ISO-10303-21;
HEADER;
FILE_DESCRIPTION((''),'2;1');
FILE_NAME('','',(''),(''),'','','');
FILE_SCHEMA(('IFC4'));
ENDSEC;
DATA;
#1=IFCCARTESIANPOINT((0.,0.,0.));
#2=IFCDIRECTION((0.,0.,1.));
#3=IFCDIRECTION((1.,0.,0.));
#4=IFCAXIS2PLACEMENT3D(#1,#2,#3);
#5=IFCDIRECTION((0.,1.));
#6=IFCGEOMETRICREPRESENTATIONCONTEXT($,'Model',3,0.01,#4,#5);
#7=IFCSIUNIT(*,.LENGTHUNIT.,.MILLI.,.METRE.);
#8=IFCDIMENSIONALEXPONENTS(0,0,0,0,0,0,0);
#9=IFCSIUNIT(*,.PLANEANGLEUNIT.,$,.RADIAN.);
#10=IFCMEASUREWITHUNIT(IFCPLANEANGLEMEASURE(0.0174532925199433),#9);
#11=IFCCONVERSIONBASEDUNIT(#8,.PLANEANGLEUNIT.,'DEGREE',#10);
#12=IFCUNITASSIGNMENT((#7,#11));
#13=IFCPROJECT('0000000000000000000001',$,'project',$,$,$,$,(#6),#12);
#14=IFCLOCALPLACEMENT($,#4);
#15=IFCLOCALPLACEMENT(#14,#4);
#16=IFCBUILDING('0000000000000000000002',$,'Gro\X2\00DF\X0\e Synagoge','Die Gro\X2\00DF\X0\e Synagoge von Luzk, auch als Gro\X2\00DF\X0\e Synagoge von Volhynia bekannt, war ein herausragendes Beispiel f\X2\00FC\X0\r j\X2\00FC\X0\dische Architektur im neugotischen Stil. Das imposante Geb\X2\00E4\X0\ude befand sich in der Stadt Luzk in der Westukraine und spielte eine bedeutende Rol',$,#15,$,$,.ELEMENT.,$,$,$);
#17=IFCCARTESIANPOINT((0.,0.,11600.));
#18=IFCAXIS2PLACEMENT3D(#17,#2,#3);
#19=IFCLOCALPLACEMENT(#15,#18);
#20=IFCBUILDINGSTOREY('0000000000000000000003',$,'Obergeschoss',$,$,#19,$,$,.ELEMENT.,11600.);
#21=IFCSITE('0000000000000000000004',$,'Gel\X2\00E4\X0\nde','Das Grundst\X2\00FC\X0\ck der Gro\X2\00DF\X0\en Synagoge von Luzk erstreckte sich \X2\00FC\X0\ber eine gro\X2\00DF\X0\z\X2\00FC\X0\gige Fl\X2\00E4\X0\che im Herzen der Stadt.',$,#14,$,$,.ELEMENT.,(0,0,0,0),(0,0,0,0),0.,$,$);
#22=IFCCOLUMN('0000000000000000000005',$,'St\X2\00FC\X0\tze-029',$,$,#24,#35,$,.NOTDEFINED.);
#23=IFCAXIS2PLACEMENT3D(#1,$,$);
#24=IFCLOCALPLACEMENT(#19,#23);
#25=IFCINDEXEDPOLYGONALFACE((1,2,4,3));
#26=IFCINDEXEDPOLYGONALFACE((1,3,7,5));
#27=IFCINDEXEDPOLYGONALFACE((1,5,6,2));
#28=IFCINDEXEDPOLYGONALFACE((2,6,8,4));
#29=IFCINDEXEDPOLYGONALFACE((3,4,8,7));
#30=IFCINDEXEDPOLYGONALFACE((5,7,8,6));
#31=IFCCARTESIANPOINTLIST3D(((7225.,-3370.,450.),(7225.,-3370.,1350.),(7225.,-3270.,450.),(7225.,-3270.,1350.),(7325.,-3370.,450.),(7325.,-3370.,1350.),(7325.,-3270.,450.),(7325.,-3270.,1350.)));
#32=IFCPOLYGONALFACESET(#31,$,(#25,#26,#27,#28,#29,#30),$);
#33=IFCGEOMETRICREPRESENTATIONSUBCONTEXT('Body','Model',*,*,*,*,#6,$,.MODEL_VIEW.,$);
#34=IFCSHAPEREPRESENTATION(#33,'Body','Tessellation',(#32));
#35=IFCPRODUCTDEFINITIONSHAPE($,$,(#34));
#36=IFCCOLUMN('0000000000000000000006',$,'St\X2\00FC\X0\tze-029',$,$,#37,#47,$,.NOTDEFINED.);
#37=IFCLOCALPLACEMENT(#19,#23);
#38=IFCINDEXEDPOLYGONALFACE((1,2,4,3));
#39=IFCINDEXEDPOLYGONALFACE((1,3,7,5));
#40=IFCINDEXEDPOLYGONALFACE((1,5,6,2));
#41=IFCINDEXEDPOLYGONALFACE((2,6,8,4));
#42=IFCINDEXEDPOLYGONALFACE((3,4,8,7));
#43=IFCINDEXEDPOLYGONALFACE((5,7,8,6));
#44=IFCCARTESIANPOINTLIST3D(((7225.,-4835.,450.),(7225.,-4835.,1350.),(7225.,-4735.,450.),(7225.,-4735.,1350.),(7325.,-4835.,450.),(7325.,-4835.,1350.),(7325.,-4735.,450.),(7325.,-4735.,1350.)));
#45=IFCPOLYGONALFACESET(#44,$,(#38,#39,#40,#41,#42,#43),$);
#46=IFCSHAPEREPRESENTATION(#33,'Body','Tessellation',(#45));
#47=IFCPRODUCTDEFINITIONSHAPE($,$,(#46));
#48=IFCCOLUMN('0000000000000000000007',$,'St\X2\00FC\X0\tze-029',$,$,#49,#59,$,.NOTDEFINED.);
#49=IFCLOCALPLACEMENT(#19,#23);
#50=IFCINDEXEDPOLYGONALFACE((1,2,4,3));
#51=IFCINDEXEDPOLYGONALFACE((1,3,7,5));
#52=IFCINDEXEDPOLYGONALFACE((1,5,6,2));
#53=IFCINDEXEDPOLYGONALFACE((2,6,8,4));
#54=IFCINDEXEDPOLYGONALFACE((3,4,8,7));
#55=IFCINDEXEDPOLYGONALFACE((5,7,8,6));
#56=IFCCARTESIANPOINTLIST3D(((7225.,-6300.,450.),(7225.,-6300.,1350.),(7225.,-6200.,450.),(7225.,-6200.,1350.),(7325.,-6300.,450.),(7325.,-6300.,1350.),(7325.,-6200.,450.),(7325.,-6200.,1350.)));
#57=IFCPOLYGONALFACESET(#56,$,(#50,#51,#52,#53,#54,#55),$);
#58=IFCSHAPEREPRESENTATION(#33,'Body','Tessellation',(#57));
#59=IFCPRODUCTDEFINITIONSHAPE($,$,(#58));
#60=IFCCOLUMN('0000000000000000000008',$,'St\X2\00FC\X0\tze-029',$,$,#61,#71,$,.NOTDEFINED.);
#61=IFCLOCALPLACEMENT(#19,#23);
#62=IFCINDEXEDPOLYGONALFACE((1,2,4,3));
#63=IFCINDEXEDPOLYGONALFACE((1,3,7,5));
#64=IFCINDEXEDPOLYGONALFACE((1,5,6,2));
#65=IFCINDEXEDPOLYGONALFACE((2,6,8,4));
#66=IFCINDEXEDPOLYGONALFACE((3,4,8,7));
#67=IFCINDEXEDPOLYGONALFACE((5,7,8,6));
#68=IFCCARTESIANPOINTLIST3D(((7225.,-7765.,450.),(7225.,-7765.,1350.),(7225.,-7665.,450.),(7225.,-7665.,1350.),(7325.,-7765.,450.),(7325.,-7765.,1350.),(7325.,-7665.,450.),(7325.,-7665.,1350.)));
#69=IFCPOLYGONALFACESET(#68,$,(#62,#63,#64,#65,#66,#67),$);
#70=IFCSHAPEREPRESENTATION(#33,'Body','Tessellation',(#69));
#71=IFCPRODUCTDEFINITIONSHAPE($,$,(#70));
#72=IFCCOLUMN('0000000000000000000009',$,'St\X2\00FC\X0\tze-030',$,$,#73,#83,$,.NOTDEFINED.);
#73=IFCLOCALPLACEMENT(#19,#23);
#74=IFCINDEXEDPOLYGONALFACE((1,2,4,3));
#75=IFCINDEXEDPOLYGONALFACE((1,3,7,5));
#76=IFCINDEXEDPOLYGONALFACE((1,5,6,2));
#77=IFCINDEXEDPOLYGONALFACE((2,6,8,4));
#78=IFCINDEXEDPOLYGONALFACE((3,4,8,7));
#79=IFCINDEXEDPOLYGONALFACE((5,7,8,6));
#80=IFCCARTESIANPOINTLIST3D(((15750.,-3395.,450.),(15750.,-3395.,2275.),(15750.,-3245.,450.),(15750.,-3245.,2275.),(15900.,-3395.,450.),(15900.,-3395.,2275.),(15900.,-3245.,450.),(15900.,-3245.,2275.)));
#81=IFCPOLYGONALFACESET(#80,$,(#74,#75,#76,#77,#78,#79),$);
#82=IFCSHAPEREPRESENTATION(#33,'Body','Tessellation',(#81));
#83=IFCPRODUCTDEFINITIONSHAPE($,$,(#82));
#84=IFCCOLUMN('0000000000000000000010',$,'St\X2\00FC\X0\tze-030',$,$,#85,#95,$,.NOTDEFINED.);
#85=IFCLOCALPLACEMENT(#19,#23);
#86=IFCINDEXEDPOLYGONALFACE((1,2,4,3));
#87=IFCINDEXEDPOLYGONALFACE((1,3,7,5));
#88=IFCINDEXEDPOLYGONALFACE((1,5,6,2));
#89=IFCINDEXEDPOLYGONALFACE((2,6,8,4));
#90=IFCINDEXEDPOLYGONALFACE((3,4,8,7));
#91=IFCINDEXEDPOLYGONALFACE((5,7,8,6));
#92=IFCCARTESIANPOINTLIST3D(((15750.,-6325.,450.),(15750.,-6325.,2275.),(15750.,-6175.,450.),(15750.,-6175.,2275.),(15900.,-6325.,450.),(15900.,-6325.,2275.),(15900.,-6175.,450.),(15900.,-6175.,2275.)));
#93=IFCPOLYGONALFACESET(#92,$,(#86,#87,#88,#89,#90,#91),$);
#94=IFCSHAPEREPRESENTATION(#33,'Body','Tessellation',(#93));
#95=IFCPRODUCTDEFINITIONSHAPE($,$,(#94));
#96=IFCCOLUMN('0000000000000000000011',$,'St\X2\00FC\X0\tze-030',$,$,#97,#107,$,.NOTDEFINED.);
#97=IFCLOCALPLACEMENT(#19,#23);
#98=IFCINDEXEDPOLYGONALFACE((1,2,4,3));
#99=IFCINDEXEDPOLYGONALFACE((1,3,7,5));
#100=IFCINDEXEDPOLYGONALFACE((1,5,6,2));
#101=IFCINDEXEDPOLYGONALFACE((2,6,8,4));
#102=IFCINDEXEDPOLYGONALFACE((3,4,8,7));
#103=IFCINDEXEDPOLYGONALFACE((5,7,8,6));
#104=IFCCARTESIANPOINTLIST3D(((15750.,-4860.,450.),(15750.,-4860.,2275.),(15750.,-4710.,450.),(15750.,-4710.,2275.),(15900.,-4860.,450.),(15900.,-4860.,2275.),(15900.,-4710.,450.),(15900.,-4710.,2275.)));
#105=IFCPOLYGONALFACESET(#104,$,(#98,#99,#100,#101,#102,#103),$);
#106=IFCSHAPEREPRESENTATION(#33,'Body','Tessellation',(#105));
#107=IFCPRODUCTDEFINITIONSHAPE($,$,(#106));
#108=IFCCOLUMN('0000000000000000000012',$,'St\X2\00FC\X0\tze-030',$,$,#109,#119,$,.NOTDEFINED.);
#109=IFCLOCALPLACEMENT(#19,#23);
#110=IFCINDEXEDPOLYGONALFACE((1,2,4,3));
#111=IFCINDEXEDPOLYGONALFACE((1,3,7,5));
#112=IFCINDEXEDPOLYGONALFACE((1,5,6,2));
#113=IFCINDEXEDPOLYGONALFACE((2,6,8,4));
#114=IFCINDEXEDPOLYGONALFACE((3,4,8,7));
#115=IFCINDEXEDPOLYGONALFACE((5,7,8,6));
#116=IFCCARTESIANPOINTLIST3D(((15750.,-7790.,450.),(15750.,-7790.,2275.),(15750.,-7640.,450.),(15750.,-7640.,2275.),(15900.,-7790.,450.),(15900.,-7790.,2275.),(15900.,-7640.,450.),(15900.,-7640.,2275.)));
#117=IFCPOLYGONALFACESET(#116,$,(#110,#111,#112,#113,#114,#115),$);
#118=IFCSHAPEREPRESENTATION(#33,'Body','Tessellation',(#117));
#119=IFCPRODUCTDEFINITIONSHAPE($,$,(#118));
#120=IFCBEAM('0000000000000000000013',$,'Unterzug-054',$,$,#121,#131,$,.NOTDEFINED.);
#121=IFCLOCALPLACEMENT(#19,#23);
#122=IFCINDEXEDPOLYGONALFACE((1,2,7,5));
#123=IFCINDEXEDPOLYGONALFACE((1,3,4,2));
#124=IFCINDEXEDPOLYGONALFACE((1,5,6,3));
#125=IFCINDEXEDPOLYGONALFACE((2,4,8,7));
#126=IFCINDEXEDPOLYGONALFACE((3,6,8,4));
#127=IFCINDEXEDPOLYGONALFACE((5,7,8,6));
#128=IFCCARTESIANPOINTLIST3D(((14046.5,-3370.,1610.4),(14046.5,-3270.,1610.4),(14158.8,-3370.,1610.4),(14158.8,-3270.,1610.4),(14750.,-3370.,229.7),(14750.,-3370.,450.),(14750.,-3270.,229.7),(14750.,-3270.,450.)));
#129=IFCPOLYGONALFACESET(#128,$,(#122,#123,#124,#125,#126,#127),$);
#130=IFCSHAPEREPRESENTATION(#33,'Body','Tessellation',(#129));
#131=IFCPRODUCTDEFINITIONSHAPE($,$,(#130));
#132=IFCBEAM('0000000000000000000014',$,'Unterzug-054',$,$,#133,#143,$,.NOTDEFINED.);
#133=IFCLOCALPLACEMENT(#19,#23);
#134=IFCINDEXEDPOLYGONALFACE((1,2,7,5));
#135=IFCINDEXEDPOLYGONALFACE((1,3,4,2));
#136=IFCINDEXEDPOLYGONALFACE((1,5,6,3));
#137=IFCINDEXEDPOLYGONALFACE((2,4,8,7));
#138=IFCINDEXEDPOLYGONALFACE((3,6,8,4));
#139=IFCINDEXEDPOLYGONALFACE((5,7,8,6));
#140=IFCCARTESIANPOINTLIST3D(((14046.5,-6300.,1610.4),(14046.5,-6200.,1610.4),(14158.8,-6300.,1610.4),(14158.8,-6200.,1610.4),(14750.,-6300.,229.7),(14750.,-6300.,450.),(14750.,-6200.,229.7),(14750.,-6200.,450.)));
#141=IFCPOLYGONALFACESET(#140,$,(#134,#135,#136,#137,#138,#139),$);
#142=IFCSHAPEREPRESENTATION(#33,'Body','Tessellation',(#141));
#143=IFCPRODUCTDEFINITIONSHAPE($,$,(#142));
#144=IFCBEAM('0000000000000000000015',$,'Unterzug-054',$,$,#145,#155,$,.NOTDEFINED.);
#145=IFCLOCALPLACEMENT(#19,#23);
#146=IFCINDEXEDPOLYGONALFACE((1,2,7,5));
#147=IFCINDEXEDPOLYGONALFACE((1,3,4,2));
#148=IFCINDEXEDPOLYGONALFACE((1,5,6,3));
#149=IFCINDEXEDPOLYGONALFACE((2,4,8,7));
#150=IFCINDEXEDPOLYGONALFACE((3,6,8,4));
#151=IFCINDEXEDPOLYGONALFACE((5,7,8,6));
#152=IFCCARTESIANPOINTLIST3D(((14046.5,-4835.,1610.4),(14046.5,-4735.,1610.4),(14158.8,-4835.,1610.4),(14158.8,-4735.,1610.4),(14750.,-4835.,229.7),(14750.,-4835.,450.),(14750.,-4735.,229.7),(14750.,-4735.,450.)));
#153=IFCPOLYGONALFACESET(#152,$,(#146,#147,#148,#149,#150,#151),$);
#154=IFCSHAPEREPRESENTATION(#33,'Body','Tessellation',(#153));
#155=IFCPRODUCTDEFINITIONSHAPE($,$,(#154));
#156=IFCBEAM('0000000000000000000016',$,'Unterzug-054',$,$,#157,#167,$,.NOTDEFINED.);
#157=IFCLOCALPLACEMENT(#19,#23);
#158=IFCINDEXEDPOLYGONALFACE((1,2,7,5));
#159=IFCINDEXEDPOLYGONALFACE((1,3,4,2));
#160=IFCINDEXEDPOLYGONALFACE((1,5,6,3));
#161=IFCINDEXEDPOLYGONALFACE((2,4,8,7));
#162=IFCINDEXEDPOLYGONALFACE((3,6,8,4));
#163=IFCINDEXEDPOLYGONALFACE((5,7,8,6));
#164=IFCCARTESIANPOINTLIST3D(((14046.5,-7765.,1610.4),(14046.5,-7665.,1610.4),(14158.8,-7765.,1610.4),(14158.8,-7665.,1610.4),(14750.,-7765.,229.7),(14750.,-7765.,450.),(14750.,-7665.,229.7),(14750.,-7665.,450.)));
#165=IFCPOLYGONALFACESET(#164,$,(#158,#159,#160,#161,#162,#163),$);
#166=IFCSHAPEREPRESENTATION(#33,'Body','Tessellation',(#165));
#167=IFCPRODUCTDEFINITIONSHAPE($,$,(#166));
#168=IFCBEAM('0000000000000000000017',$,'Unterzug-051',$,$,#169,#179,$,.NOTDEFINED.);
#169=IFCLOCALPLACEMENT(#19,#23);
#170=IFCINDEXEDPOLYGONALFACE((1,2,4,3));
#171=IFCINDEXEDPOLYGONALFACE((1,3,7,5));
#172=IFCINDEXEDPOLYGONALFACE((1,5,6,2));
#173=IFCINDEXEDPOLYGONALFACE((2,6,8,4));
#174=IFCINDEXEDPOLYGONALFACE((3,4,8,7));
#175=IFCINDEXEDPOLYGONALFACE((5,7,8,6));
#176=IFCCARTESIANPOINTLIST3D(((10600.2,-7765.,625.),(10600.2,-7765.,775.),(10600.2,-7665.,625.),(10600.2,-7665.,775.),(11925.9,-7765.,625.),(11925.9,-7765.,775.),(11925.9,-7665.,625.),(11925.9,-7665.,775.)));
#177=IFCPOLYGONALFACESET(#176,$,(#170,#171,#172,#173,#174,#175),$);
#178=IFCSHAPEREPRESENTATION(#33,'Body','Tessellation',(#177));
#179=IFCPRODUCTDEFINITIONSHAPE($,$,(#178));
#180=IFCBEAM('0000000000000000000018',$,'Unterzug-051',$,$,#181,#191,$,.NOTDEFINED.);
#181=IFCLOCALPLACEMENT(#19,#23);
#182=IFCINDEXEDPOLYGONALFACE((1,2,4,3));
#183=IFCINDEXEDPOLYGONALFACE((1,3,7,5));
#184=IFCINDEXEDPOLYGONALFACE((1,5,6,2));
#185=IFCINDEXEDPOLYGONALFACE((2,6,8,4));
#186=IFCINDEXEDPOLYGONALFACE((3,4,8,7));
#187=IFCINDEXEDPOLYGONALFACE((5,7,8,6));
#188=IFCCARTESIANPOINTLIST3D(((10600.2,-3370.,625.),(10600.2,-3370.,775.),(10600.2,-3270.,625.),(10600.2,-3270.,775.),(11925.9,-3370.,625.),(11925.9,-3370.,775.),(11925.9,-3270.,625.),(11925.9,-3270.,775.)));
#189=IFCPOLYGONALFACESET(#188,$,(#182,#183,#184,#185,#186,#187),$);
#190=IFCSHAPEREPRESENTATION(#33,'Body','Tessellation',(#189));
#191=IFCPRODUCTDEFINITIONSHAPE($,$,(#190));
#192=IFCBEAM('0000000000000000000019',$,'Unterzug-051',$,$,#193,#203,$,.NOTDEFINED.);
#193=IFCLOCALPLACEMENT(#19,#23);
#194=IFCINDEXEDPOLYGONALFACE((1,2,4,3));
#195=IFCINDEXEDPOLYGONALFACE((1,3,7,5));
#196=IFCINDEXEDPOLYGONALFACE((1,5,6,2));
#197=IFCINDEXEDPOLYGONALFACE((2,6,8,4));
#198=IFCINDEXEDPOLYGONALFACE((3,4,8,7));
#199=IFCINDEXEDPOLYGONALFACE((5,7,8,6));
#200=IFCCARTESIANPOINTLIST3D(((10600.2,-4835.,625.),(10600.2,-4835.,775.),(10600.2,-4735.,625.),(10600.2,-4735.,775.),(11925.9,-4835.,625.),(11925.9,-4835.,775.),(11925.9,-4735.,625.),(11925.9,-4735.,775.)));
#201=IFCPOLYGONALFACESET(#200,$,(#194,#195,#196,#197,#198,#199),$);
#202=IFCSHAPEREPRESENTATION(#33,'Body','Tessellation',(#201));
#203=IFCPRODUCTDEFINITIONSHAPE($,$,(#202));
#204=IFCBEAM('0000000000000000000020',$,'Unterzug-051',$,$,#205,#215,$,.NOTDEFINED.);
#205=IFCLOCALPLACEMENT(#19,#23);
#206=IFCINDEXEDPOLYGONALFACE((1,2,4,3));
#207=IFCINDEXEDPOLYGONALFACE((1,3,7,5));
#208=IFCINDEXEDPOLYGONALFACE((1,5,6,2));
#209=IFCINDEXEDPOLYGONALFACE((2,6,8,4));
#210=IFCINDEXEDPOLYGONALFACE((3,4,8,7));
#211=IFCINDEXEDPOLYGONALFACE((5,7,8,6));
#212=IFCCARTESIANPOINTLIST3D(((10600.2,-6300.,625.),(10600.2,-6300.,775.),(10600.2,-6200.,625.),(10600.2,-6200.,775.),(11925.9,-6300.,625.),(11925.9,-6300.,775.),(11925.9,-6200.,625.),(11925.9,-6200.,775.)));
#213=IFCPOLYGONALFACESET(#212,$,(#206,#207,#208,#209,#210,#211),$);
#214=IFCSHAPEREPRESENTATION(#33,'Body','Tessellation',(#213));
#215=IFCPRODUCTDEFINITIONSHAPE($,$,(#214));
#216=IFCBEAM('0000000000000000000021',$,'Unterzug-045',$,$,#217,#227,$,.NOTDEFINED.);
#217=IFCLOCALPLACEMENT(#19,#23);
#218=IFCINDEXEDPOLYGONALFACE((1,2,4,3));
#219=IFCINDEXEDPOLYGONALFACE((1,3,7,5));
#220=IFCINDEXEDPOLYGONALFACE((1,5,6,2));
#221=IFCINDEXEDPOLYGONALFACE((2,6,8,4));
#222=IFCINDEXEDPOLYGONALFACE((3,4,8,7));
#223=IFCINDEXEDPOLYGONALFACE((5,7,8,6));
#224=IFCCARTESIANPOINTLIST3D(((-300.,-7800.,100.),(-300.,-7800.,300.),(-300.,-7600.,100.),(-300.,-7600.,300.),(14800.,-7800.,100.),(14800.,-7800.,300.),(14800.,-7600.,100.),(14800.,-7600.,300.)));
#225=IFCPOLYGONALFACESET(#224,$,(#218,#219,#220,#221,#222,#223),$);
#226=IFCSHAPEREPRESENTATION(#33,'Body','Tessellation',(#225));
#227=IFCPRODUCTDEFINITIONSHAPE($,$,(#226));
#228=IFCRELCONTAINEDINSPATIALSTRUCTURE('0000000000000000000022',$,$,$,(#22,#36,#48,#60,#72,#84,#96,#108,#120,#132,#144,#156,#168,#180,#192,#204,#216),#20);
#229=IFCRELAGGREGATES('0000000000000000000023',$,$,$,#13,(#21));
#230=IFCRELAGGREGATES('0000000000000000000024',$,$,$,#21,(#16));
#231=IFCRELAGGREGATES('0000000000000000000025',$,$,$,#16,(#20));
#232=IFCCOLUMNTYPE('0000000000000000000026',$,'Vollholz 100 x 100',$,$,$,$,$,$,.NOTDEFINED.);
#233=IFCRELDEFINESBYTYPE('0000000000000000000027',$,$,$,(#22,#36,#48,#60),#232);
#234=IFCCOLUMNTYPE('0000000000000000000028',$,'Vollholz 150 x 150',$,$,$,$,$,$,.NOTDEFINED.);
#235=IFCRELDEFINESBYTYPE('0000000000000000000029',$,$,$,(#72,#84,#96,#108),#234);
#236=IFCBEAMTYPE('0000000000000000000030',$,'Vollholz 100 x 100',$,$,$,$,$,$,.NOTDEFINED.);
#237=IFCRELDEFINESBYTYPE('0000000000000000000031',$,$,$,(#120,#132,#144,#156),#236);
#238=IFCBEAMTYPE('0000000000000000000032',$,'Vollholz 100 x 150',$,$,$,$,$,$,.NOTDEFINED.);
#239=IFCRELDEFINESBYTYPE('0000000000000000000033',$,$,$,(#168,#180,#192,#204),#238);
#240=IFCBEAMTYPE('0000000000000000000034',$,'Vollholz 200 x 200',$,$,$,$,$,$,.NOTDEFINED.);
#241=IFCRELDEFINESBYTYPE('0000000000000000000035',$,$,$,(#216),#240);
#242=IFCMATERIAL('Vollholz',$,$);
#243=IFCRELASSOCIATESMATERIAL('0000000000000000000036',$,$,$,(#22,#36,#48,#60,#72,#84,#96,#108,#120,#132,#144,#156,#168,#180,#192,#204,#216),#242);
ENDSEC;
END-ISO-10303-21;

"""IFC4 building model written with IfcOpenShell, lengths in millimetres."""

from ifc_helpers import new_model, entity, si_unit, converted_unit, direction, frame, frame_2d, origin_with_axes, origin_2d_with_axis, place, context, subcontext, project, spatial, rectangle, extrude, clip, halfspace, material, type_object, element, save


model = new_model("IFC4")

# Units and contexts
model_context = context("Model", 3, precision=0.01, world=origin_with_axes(), true_north=direction((0.0, 1.0)))
body_context = subcontext(model_context, "Body", "Model", "MODEL_VIEW")
ifc_project = project(units=[si_unit("LENGTHUNIT", "METRE", prefix="MILLI"), converted_unit("PLANEANGLEUNIT", "DEGREE", entity("IfcPlaneAngleMeasure", 0.0174532925199433), si_unit("PLANEANGLEUNIT", "RADIAN"), dimensions=[0, 0, 0, 0, 0, 0, 0])], contexts=[model_context])

# Site, building, storey
site_placement = place(None, origin_with_axes())
site = spatial("IfcSite", under=ifc_project, at=site_placement, Name="Gelände", Description="Das Grundstück der Großen Synagoge von Luzk erstreckte sich über eine großzügige Fläche im Herzen der Stadt.", CompositionType="ELEMENT", RefLatitude=(0, 0, 0, 0), RefLongitude=(0, 0, 0, 0), RefElevation=0.0)
building_placement = place(site_placement, origin_with_axes())
building = spatial("IfcBuilding", under=site, at=building_placement, Name="Große Synagoge", Description="Die Große Synagoge von Luzk, auch als Große Synagoge von Volhynia bekannt, war ein herausragendes Beispiel für jüdische Architektur im neugotischen Stil. Das imposante Gebäude befand sich in der Stadt Luzk in der Westukraine und spielte eine bedeutende Rol", CompositionType="ELEMENT")
storey_placement = place(building_placement, frame((0.0, 0.0, 11600.0), z_axis=(0.0, 0.0, 1.0), x_axis=(1.0, 0.0, 0.0)))
storey = spatial("IfcBuildingStorey", under=building, at=storey_placement, Name="Obergeschoss", CompositionType="ELEMENT", Elevation=11600.0)

# Columns
ifc_material = material(Name="Vollholz")
column_type_1 = type_object("IfcColumnType", Name="Vollholz 100 x 100", PredefinedType="NOTDEFINED")
for number, where, z_axis, x_axis, name in (
    (1, (7275.0, -3320.0, 450.0), (0.0, 0.0, 1.0), (1.0, 0.0, 0.0), "Stütze-029"),
    (2, (7275.0, -4785.0, 450.0), (0.0, 0.0, 1.0), (1.0, 0.0, 0.0), "Stütze-029"),
    (3, (7275.0, -6250.0, 450.0), (0.0, 0.0, 1.0), (1.0, 0.0, 0.0), "Stütze-029"),
    (4, (7275.0, -7715.0, 450.0), (0.0, 0.0, 1.0), (1.0, 0.0, 0.0), "Stütze-029"),
):
    element("IfcColumn", number, at=place(storey_placement, frame(where, z_axis=z_axis, x_axis=x_axis)), inside=storey, type_object=column_type_1, material=ifc_material, Name=name, PredefinedType="NOTDEFINED", context=body_context, shape_type="SweptSolid", body=[
        extrude(rectangle(XDim=100.0, YDim=100.0, at=origin_2d_with_axis()), origin_with_axes(), (0.0, 0.0, 1.0), 900.0),
    ])
column_type_2 = type_object("IfcColumnType", Name="Vollholz 150 x 150", PredefinedType="NOTDEFINED")
for number, where, z_axis, x_axis, name in (
    (5, (15825.0, -3320.0, 450.0), (0.0, 0.0, 1.0), (1.0, 0.0, 0.0), "Stütze-030"),
    (6, (15825.0, -6250.0, 450.0), (0.0, 0.0, 1.0), (1.0, 0.0, 0.0), "Stütze-030"),
    (7, (15825.0, -4785.0, 450.0), (0.0, 0.0, 1.0), (1.0, 0.0, 0.0), "Stütze-030"),
    (8, (15825.0, -7715.0, 450.0), (0.0, 0.0, 1.0), (1.0, 0.0, 0.0), "Stütze-030"),
):
    element("IfcColumn", number, at=place(storey_placement, frame(where, z_axis=z_axis, x_axis=x_axis)), inside=storey, type_object=column_type_2, material=ifc_material, Name=name, PredefinedType="NOTDEFINED", context=body_context, shape_type="SweptSolid", body=[
        extrude(rectangle(XDim=150.0, YDim=150.0, at=origin_2d_with_axis()), origin_with_axes(), (0.0, 0.0, 1.0), 1825.0),
    ])

# Beams
beam_type_1 = type_object("IfcBeamType", Name="Vollholz 100 x 100", PredefinedType="NOTDEFINED")
for number, where, z_axis, x_axis, name in (
    (9, (14750.0, -3320.0, 450.0), (0.0, 0.0, 1.0), (0.0, 1.0, 0.0), "Unterzug-054"),
    (10, (14750.0, -6250.0, 450.0), (0.0, 0.0, 1.0), (0.0, 1.0, 0.0), "Unterzug-054"),
    (11, (14750.0, -4785.0, 450.0), (0.0, 0.0, 1.0), (0.0, 1.0, 0.0), "Unterzug-054"),
    (12, (14750.0, -7715.0, 450.0), (0.0, 0.0, 1.0), (0.0, 1.0, 0.0), "Unterzug-054"),
):
    element("IfcBeam", number, at=place(storey_placement, frame(where, z_axis=z_axis, x_axis=x_axis)), inside=storey, type_object=beam_type_1, material=ifc_material, Name=name, PredefinedType="NOTDEFINED", context=body_context, shape_type="Clipping", body=[
        clip(clip(extrude(rectangle(XDim=100.0, YDim=100.0, at=frame_2d((-50.0, 0.0), x_axis=(1.0, 0.0))), frame((0.0, -126.0, -247.3), z_axis=(0.0, 0.45399, 0.891007), x_axis=(0.0, -0.891007, 0.45399)), (0.0, 0.0, 1.0), 1651.9), halfspace(frame((0.0, 0.0, 0.0), z_axis=(0.0, 1.0, 0.0), x_axis=(0.0, 0.0, 1.0)), True)), halfspace(frame((0.0, 0.0, 1160.4), z_axis=(0.0, 0.0, -1.0), x_axis=(0.0, 1.0, 0.0)), True)),
    ])
beam_type_2 = type_object("IfcBeamType", Name="Vollholz 100 x 150", PredefinedType="NOTDEFINED")
for number, where, z_axis, x_axis, name in (
    (13, (11925.9, -7715.0, 775.0), (0.0, 0.0, 1.0), (0.0, 1.0, 0.0), "Unterzug-051"),
    (14, (11925.9, -3320.0, 775.0), (0.0, 0.0, 1.0), (0.0, 1.0, 0.0), "Unterzug-051"),
    (15, (11925.9, -4785.0, 775.0), (0.0, 0.0, 1.0), (0.0, 1.0, 0.0), "Unterzug-051"),
    (16, (11925.9, -6250.0, 775.0), (0.0, 0.0, 1.0), (0.0, 1.0, 0.0), "Unterzug-051"),
):
    element("IfcBeam", number, at=place(storey_placement, frame(where, z_axis=z_axis, x_axis=x_axis)), inside=storey, type_object=beam_type_2, material=ifc_material, Name=name, PredefinedType="NOTDEFINED", context=body_context, shape_type="SweptSolid", body=[
        extrude(rectangle(XDim=150.0, YDim=100.0, at=frame_2d((-75.0, 0.0), x_axis=(1.0, 0.0))), frame((0.0, 0.0, 0.0), z_axis=(0.0, 1.0, 0.0), x_axis=(0.0, 0.0, 1.0)), (0.0, 0.0, 1.0), 1325.7),
    ])
beam_type_3 = type_object("IfcBeamType", Name="Vollholz 200 x 200", PredefinedType="NOTDEFINED")
beam_placement = place(storey_placement, frame((14800.0, -7700.0, 300.0), z_axis=(0.0, 0.0, 1.0), x_axis=(0.0, 1.0, 0.0)))
element("IfcBeam", 17, at=beam_placement, inside=storey, type_object=beam_type_3, material=ifc_material, Name="Unterzug-045", PredefinedType="NOTDEFINED", context=body_context, shape_type="SweptSolid", body=[
    extrude(rectangle(XDim=200.0, YDim=200.0, at=frame_2d((-100.0, 0.0), x_axis=(1.0, 0.0))), frame((0.0, 0.0, 0.0), z_axis=(0.0, 1.0, 0.0), x_axis=(0.0, 0.0, 1.0)), (0.0, 0.0, 1.0), 15100.0),
])

save(model, "model.ifc")
